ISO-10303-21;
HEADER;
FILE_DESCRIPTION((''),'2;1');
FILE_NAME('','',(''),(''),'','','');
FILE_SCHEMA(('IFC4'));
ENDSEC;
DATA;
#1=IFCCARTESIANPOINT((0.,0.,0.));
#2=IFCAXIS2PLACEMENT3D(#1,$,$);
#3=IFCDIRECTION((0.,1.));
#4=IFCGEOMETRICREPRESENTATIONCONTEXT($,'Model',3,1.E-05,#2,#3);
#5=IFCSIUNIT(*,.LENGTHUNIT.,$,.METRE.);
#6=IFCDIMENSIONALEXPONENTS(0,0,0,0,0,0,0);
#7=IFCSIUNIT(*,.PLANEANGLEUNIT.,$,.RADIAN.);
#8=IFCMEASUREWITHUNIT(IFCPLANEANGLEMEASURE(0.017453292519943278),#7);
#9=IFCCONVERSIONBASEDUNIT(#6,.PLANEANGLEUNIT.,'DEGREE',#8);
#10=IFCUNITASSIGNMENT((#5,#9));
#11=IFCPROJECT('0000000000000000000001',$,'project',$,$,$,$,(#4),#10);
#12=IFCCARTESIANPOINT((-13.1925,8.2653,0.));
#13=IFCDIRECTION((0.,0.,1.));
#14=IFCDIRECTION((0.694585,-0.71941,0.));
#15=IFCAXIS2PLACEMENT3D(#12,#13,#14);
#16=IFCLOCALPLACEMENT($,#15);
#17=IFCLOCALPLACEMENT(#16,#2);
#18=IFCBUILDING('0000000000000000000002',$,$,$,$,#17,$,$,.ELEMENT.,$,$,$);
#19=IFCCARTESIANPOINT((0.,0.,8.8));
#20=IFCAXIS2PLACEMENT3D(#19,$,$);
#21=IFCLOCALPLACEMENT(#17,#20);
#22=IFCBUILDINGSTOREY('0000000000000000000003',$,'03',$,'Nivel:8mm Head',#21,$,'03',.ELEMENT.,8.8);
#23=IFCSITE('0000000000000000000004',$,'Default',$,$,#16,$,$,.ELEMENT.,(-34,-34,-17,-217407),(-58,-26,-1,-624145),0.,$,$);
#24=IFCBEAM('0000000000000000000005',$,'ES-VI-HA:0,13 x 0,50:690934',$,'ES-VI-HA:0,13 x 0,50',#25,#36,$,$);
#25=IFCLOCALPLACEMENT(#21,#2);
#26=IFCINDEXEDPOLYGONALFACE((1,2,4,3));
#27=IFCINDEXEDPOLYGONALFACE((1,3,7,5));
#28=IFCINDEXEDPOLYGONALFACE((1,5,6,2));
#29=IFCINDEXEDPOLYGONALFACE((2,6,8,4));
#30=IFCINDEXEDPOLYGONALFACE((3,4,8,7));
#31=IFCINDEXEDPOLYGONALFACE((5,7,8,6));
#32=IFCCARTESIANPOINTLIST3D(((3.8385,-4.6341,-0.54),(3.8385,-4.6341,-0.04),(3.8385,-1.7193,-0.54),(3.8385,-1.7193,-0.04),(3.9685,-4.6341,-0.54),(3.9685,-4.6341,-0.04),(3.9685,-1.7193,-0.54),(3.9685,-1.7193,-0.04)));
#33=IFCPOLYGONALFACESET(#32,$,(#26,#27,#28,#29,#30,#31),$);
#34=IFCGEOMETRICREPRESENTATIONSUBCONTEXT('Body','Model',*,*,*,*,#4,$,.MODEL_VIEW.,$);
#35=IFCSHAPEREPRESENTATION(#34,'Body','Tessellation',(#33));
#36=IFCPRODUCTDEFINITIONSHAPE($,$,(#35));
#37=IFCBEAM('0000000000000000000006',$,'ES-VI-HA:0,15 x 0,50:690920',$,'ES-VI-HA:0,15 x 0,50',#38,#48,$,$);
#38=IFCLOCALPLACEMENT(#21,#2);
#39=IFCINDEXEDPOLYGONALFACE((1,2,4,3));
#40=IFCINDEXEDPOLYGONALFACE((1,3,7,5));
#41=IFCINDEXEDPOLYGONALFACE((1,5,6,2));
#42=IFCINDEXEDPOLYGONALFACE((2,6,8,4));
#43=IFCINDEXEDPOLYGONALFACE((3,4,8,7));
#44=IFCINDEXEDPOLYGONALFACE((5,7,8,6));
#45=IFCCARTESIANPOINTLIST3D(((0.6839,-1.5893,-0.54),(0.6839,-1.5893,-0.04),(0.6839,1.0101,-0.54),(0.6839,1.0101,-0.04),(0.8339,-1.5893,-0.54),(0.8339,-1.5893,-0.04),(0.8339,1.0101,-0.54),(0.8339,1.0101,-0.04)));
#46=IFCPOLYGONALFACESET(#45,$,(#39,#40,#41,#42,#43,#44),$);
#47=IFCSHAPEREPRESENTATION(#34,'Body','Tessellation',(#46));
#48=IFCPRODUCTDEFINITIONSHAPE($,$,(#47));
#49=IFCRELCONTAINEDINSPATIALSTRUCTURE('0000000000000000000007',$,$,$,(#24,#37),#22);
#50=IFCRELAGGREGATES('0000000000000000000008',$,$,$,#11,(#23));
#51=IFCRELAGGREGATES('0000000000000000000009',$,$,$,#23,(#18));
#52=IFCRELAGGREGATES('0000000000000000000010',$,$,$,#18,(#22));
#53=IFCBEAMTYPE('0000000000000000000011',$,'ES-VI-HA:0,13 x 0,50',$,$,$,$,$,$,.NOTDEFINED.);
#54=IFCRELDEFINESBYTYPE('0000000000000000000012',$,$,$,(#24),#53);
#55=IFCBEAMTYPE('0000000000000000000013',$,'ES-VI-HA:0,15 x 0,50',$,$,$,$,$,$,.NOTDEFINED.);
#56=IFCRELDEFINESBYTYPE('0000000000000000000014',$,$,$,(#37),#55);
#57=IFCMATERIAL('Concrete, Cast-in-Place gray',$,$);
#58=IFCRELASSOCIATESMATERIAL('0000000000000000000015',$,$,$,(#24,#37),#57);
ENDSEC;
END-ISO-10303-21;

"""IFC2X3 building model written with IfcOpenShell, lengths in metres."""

from ifc_helpers import new_model, entity, si_unit, converted_unit, direction, frame, frame_2d, origin, origin_2d_with_axis, place, context, subcontext, project, spatial, rectangle, extrude, material, type_object, element, save


model = new_model("IFC2X3")

# Units and contexts
model_context = context("Model", 3, precision=1e-05, world=origin(), true_north=direction((0.0, 1.0)))
body_context = subcontext(model_context, "Body", "Model", "MODEL_VIEW")
ifc_project = project(units=[si_unit("LENGTHUNIT", "METRE"), converted_unit("PLANEANGLEUNIT", "DEGREE", entity("IfcPlaneAngleMeasure", 0.017453292519943278), si_unit("PLANEANGLEUNIT", "RADIAN"), dimensions=[0, 0, 0, 0, 0, 0, 0])], contexts=[model_context])

# Site, building, storey
site_placement = place(None, frame((-13.1925, 8.2653, 0.0), z_axis=(0.0, 0.0, 1.0), x_axis=(0.694585, -0.71941, 0.0)))
site = spatial("IfcSite", under=ifc_project, at=site_placement, Name="Default", CompositionType="ELEMENT", RefLatitude=(-34, -34, -17, -217407), RefLongitude=(-58, -26, -1, -624145), RefElevation=0.0)
building_placement = place(site_placement, origin())
building = spatial("IfcBuilding", under=site, at=building_placement, CompositionType="ELEMENT")
storey_placement = place(building_placement, frame((0.0, 0.0, 8.8)))
storey = spatial("IfcBuildingStorey", under=building, at=storey_placement, Name="03", ObjectType="Nivel:8mm Head", LongName="03", CompositionType="ELEMENT", Elevation=8.8)

# Beams
ifc_material_1 = material(Name="Concrete, Cast-in-Place gray")
beam_type_1 = type_object("IfcBeamType", Name="ES-VI-HA:0,13 x 0,50", PredefinedType="NOTDEFINED")
beam_1_placement = place(storey_placement, frame((3.9035, -4.7011, -0.04), z_axis=(0.0, 0.0, 1.0), x_axis=(0.0, 1.0, 0.0)))
element("IfcBeam", 1, at=beam_1_placement, inside=storey, type_object=beam_type_1, material=ifc_material_1, Name="ES-VI-HA:0,13 x 0,50:690934", ObjectType="ES-VI-HA:0,13 x 0,50", context=body_context, shape_type="SweptSolid", body=[
    extrude(rectangle(XDim=0.5, YDim=0.13, at=origin_2d_with_axis()), frame((0.067, 0.0, -0.25), z_axis=(1.0, 0.0, 0.0), x_axis=(0.0, 0.0, -1.0)), (0.0, 0.0, 1.0), 2.9148),
])
beam_type_2 = type_object("IfcBeamType", Name="ES-VI-HA:0,15 x 0,50", PredefinedType="NOTDEFINED")
beam_2_placement = place(storey_placement, frame((0.7589, -1.6543, -0.04), z_axis=(0.0, 0.0, 1.0), x_axis=(0.0, 1.0, 0.0)))
element("IfcBeam", 2, at=beam_2_placement, inside=storey, type_object=beam_type_2, material=ifc_material_1, Name="ES-VI-HA:0,15 x 0,50:690920", ObjectType="ES-VI-HA:0,15 x 0,50", context=body_context, shape_type="SweptSolid", body=[
    extrude(rectangle(XDim=0.5, YDim=0.15, at=frame_2d((0.0, 0.0), x_axis=(1.0, 0.0))), frame((0.065, 0.0, -0.25), z_axis=(1.0, 0.0, 0.0), x_axis=(0.0, 0.0, -1.0)), (0.0, 0.0, 1.0), 2.5994),
])

save(model, "model.ifc")
